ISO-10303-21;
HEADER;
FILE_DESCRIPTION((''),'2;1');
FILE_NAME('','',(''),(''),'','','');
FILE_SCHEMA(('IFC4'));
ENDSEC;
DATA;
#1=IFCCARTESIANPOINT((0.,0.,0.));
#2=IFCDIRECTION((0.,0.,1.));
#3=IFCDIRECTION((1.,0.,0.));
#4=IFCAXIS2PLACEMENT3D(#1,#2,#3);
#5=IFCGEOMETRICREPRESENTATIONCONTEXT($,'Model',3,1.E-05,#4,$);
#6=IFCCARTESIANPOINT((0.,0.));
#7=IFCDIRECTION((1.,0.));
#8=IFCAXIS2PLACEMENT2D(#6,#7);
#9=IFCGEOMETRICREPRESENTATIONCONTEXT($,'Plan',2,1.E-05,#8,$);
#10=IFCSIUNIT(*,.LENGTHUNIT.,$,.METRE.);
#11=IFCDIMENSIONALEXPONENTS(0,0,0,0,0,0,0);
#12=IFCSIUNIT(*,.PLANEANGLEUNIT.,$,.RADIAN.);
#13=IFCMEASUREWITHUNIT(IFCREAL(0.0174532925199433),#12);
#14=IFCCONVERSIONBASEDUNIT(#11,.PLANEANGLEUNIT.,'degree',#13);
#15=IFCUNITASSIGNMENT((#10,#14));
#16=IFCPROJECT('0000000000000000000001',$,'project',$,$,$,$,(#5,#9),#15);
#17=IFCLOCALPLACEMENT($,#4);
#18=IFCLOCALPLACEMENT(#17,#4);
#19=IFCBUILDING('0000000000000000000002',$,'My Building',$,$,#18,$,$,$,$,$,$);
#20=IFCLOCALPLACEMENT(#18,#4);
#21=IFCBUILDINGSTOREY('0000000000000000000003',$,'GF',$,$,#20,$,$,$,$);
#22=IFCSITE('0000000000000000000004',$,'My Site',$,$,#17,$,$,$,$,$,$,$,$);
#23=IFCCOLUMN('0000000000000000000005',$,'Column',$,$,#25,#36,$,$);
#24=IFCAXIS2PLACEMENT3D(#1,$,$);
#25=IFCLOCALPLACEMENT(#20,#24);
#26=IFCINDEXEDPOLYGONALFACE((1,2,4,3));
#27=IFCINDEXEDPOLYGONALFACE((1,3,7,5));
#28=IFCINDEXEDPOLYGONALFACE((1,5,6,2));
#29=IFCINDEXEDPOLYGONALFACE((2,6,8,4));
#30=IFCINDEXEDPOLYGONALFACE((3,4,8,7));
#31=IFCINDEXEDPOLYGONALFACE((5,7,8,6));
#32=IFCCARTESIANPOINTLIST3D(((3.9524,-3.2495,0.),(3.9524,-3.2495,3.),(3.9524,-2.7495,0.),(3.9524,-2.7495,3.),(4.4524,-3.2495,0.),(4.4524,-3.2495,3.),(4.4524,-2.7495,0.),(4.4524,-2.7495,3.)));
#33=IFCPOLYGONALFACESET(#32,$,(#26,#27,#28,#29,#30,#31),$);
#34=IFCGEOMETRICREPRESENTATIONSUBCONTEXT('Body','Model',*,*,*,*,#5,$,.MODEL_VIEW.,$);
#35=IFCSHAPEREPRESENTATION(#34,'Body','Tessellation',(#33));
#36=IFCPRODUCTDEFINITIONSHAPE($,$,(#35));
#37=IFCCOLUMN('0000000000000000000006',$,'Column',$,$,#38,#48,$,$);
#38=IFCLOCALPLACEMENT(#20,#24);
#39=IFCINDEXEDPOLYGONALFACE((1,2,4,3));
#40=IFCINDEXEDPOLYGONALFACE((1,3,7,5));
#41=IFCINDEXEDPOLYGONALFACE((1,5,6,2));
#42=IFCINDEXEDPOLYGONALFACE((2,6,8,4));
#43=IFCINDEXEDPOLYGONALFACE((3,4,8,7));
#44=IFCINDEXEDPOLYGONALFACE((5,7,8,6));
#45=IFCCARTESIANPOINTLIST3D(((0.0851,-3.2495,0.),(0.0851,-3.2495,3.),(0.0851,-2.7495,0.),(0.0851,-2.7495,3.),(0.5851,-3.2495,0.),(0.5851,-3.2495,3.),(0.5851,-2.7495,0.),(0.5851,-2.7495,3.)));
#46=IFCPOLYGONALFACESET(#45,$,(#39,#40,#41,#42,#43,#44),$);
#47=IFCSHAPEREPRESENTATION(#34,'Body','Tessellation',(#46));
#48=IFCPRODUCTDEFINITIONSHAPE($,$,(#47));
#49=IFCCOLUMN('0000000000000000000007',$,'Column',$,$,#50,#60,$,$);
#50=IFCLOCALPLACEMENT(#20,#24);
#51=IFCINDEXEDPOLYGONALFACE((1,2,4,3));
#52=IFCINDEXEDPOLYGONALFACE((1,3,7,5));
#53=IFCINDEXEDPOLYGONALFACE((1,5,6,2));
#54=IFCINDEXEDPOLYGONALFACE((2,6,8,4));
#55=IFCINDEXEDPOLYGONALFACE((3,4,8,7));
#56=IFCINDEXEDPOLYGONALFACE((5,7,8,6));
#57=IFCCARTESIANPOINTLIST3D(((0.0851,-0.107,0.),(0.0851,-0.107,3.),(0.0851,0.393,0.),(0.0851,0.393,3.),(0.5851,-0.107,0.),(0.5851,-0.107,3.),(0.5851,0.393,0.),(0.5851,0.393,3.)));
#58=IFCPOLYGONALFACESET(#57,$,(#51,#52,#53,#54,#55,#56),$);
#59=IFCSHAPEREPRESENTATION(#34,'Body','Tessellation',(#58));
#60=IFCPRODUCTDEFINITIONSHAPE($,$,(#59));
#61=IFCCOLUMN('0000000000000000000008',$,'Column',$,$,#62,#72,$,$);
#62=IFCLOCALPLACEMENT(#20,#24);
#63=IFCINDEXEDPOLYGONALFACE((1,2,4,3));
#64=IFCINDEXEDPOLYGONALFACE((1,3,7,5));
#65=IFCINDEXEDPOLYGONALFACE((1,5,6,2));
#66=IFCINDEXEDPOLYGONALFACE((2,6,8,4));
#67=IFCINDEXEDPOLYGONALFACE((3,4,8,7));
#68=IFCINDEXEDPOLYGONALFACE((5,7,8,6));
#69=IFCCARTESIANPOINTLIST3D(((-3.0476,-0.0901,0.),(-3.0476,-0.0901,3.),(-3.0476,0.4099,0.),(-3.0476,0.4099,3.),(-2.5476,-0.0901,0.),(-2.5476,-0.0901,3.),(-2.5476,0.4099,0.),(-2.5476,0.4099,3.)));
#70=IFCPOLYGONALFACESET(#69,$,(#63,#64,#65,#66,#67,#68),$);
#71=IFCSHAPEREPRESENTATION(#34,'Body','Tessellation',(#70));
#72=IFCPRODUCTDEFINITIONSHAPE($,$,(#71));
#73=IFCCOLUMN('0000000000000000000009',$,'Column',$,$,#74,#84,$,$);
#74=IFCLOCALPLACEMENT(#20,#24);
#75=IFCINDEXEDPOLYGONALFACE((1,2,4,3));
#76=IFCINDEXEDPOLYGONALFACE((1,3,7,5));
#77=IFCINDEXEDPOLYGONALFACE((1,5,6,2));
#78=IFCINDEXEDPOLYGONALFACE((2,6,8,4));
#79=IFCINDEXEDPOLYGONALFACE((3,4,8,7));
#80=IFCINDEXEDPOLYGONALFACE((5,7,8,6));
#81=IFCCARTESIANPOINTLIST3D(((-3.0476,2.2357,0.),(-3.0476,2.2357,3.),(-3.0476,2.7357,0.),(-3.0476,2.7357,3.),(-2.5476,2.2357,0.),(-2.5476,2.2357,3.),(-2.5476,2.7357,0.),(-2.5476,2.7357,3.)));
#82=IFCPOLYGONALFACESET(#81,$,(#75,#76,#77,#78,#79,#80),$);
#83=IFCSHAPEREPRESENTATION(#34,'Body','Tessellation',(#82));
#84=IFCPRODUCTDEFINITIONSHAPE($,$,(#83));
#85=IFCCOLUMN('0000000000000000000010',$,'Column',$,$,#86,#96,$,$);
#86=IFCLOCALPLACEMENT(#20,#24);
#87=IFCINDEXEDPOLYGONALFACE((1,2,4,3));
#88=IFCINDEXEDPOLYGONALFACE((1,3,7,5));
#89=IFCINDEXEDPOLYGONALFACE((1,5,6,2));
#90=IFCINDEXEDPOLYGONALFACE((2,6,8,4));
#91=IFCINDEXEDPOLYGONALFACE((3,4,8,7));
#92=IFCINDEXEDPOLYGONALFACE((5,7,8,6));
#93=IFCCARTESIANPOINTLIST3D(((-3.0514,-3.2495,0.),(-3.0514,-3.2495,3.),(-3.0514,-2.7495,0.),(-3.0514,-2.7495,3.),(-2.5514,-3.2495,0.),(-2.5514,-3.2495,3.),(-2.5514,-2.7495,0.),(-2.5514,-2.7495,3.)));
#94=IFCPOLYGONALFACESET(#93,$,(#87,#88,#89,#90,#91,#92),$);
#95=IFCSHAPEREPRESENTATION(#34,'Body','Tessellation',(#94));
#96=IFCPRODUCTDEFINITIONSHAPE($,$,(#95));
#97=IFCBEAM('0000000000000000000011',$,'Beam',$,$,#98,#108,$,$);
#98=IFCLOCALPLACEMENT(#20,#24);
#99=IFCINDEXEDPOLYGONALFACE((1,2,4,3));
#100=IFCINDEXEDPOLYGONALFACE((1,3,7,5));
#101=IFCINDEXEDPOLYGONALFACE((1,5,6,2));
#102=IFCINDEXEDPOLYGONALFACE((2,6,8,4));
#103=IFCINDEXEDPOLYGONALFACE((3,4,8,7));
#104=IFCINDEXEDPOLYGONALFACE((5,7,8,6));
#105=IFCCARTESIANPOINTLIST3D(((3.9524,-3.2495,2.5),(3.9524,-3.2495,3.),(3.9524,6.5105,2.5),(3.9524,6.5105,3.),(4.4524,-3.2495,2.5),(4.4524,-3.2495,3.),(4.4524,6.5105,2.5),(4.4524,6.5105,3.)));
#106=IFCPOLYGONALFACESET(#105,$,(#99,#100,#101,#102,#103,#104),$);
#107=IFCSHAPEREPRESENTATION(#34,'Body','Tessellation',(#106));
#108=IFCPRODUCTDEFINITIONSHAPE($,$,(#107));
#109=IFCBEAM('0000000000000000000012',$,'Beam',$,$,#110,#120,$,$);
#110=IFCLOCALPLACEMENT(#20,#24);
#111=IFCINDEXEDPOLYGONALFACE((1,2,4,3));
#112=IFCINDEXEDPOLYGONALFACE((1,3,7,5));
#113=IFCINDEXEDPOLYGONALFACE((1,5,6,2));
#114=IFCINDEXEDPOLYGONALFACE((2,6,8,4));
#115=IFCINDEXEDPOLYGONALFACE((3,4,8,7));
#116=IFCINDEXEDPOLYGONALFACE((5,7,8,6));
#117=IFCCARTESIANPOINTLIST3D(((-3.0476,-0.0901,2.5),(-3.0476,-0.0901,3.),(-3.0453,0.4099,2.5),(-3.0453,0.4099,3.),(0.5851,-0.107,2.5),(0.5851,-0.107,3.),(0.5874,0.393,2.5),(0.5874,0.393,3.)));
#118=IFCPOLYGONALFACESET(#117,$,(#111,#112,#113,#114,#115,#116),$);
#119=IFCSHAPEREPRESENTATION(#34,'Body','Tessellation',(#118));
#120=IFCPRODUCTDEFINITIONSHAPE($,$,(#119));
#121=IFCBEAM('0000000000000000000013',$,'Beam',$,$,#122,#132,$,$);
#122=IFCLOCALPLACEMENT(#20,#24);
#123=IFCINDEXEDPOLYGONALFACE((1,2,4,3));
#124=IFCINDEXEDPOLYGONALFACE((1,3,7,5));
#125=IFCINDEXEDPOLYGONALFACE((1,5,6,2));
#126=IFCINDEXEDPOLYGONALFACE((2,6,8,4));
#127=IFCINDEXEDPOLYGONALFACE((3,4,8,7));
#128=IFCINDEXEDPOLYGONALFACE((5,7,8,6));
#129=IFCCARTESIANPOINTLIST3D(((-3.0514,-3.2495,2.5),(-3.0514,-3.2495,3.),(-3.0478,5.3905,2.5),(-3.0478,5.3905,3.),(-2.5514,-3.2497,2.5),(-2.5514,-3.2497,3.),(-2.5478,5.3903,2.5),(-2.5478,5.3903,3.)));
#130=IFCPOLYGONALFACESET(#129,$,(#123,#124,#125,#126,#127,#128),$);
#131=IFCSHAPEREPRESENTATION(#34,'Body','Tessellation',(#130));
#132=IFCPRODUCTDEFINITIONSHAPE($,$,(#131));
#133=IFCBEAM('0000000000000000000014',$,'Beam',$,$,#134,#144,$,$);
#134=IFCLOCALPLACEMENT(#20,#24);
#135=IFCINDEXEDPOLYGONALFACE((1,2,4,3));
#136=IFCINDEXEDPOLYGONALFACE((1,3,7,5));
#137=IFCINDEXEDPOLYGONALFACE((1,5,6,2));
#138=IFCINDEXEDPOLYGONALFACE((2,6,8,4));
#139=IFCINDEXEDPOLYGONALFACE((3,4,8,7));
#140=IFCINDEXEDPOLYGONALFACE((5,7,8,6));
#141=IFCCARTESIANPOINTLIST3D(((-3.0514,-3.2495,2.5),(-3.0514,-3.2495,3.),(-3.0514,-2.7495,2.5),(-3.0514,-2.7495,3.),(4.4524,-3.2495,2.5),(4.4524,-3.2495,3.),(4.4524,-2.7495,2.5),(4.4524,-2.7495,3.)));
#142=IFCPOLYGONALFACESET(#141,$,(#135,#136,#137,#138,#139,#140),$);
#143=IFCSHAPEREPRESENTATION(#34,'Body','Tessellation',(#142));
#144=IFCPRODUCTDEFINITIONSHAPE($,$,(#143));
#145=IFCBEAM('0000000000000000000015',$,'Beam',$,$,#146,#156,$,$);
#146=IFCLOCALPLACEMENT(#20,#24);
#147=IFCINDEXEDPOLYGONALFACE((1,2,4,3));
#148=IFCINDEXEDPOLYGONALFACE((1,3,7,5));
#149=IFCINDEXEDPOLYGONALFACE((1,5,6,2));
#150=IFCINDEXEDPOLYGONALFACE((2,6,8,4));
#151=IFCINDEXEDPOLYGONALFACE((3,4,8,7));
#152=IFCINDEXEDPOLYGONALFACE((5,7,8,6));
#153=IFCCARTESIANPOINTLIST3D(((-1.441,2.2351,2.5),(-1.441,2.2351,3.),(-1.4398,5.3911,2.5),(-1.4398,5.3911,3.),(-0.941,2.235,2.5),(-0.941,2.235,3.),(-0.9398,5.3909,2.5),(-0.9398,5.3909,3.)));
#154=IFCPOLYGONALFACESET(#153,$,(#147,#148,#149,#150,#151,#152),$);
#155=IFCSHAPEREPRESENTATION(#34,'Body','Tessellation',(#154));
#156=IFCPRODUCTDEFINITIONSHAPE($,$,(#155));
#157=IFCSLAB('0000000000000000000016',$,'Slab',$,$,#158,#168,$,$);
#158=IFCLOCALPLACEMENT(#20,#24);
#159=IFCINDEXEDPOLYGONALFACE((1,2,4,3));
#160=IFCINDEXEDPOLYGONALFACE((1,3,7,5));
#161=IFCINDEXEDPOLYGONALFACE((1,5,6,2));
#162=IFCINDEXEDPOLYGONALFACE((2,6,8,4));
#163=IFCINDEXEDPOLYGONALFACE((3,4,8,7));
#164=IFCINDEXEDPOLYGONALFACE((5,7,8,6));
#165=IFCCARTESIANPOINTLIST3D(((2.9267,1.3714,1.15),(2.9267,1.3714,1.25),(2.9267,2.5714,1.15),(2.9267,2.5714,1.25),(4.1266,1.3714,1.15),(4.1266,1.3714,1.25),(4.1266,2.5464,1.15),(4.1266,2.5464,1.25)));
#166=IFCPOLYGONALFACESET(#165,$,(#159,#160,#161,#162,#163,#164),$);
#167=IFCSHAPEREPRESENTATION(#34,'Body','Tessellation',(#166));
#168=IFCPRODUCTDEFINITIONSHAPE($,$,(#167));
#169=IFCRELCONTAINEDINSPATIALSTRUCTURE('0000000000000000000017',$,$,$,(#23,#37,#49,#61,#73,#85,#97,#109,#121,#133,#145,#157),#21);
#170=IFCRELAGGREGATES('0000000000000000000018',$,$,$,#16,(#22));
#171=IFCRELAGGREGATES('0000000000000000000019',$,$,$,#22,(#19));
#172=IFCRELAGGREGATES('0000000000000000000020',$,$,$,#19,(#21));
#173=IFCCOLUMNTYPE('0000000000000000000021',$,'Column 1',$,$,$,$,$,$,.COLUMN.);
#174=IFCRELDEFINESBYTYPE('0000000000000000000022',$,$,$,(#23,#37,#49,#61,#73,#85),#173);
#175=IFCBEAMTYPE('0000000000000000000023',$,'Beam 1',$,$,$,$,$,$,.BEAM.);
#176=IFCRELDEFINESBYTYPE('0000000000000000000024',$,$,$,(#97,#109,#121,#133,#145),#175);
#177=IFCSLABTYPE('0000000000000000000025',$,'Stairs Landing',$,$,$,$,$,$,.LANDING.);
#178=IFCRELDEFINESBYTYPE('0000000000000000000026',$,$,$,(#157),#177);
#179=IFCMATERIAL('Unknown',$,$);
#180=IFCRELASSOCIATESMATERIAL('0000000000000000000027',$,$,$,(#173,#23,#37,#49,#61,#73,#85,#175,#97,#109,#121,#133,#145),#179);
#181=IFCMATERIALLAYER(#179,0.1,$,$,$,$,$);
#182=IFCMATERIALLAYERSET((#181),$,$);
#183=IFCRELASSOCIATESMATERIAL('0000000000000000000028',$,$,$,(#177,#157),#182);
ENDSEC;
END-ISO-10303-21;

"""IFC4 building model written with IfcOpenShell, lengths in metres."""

from ifc_helpers import new_model, entity, si_unit, converted_unit, frame, origin_with_axes, origin_2d_with_axis, place, context, subcontext, project, spatial, indexed_curve, outline, extrude, material, layer, layer_set, layer_usage, material_profile, profile_set, profile_usage, type_object, element, save


model = new_model("IFC4")

# Units and contexts
model_context = context("Model", 3, precision=1e-05, world=origin_with_axes())
plan_context = context("Plan", 2, precision=1e-05, world=origin_2d_with_axis())
body_context_1 = subcontext(model_context, "Body", "Model", "MODEL_VIEW")
ifc_project = project(units=[si_unit("LENGTHUNIT", "METRE"), converted_unit("PLANEANGLEUNIT", "degree", entity("IfcReal", 0.0174532925199433), si_unit("PLANEANGLEUNIT", "RADIAN"), dimensions=[0, 0, 0, 0, 0, 0, 0])], contexts=[model_context, plan_context])

# Site, building, storey
site_placement = place(None, origin_with_axes())
site = spatial("IfcSite", under=ifc_project, at=site_placement, Name="My Site")
building_placement = place(site_placement, origin_with_axes())
building = spatial("IfcBuilding", under=site, at=building_placement, Name="My Building")
storey_placement = place(building_placement, origin_with_axes())
storey = spatial("IfcBuildingStorey", under=building, at=storey_placement, Name="GF")

# Columns
ifc_material = material(Name="Unknown")
ifc_material_profile_1 = material_profile(ifc_material, outline(indexed_curve([(-0.25, -0.25), (0.25, -0.25), (0.25, 0.25), (-0.25, 0.25), (-0.25, -0.25)])))
ifc_profile_set_1 = profile_set([ifc_material_profile_1])
ifc_profile_usage_1 = profile_usage(ifc_profile_set_1, cardinal=1)
column_type = type_object("IfcColumnType", Name="Column 1", PredefinedType="COLUMN", material=ifc_profile_set_1)
column_1_placement = place(storey_placement, frame((4.4524, -3.2495, 0.0), z_axis=(0.0, 0.0, 1.0), x_axis=(1.0, 0.0, 0.0)))
element("IfcColumn", 1, at=column_1_placement, inside=storey, type_object=column_type, material=ifc_profile_usage_1, Name="Column", context=body_context_1, shape_type="SweptSolid", body=[
    extrude(outline(indexed_curve([(-0.25, -0.25), (0.25, -0.25), (0.25, 0.25), (-0.25, 0.25), (-0.25, -0.25)])), frame((-0.25, 0.25, 0.0), z_axis=(0.0, 0.0, 1.0), x_axis=(1.0, 0.0, 0.0)), (0.0, 0.0, 1.0), 3.0),
])
ifc_profile_usage_2 = profile_usage(ifc_profile_set_1, cardinal=1)
column_2_placement = place(storey_placement, frame((0.5851, -3.2495, 0.0), z_axis=(0.0, 0.0, 1.0), x_axis=(1.0, 0.0, 0.0)))
element("IfcColumn", 2, at=column_2_placement, inside=storey, type_object=column_type, material=ifc_profile_usage_2, Name="Column", context=body_context_1, shape_type="SweptSolid", body=[
    extrude(outline(indexed_curve([(-0.25, -0.25), (0.25, -0.25), (0.25, 0.25), (-0.25, 0.25), (-0.25, -0.25)])), frame((-0.25, 0.25, 0.0), z_axis=(0.0, 0.0, 1.0), x_axis=(1.0, 0.0, 0.0)), (0.0, 0.0, 1.0), 3.0),
])
ifc_profile_usage_3 = profile_usage(ifc_profile_set_1, cardinal=3)
column_3_placement = place(storey_placement, frame((0.0851, -0.107, 0.0), z_axis=(0.0, 0.0, 1.0), x_axis=(1.0, 0.0, 0.0)))
element("IfcColumn", 3, at=column_3_placement, inside=storey, type_object=column_type, material=ifc_profile_usage_3, Name="Column", context=body_context_1, shape_type="SweptSolid", body=[
    extrude(outline(indexed_curve([(-0.25, -0.25), (0.25, -0.25), (0.25, 0.25), (-0.25, 0.25), (-0.25, -0.25)])), frame((0.25, 0.25, 0.0), z_axis=(0.0, 0.0, 1.0), x_axis=(1.0, 0.0, 0.0)), (0.0, 0.0, 1.0), 3.0),
])
ifc_profile_usage_4 = profile_usage(ifc_profile_set_1, cardinal=3)
column_4_placement = place(storey_placement, frame((-3.0476, -0.0901, 0.0), z_axis=(0.0, 0.0, 1.0), x_axis=(1.0, 0.0, 0.0)))
element("IfcColumn", 4, at=column_4_placement, inside=storey, type_object=column_type, material=ifc_profile_usage_4, Name="Column", context=body_context_1, shape_type="SweptSolid", body=[
    extrude(outline(indexed_curve([(-0.25, -0.25), (0.25, -0.25), (0.25, 0.25), (-0.25, 0.25), (-0.25, -0.25)])), frame((0.25, 0.25, 0.0), z_axis=(0.0, 0.0, 1.0), x_axis=(1.0, 0.0, 0.0)), (0.0, 0.0, 1.0), 3.0),
])
ifc_profile_usage_5 = profile_usage(ifc_profile_set_1, cardinal=3)
column_5_placement = place(storey_placement, frame((-3.0476, 2.2357, 0.0), z_axis=(0.0, 0.0, 1.0), x_axis=(1.0, 0.0, 0.0)))
element("IfcColumn", 5, at=column_5_placement, inside=storey, type_object=column_type, material=ifc_profile_usage_5, Name="Column", context=body_context_1, shape_type="SweptSolid", body=[
    extrude(outline(indexed_curve([(-0.25, -0.25), (0.25, -0.25), (0.25, 0.25), (-0.25, 0.25), (-0.25, -0.25)])), frame((0.25, 0.25, 0.0), z_axis=(0.0, 0.0, 1.0), x_axis=(1.0, 0.0, 0.0)), (0.0, 0.0, 1.0), 3.0),
])
ifc_profile_usage_6 = profile_usage(ifc_profile_set_1, cardinal=1)
column_6_placement = place(storey_placement, frame((-2.5514, -3.2495, 0.0), z_axis=(0.0, 0.0, 1.0), x_axis=(1.0, 0.0, 0.0)))
element("IfcColumn", 6, at=column_6_placement, inside=storey, type_object=column_type, material=ifc_profile_usage_6, Name="Column", context=body_context_1, shape_type="SweptSolid", body=[
    extrude(outline(indexed_curve([(-0.25, -0.25), (0.25, -0.25), (0.25, 0.25), (-0.25, 0.25), (-0.25, -0.25)])), frame((-0.25, 0.25, 0.0), z_axis=(0.0, 0.0, 1.0), x_axis=(1.0, 0.0, 0.0)), (0.0, 0.0, 1.0), 3.0),
])

# Beams
ifc_material_profile_2 = material_profile(ifc_material, outline(indexed_curve([(-0.25, -0.25), (0.25, -0.25), (0.25, 0.25), (-0.25, 0.25), (-0.25, -0.25)])))
ifc_profile_set_2 = profile_set([ifc_material_profile_2])
ifc_profile_usage_7 = profile_usage(ifc_profile_set_2, cardinal=9)
beam_type = type_object("IfcBeamType", Name="Beam 1", PredefinedType="BEAM", material=ifc_profile_set_2)
beam_1_placement = place(storey_placement, frame((4.4524, -3.2495, 3.0), z_axis=(0.0, 1.0, 0.0), x_axis=(-1.0, 0.0, 0.0)))
element("IfcBeam", 7, at=beam_1_placement, inside=storey, type_object=beam_type, material=ifc_profile_usage_7, Name="Beam", context=body_context_1, shape_type="SweptSolid", body=[
    extrude(outline(indexed_curve([(-0.25, -0.25), (0.25, -0.25), (0.25, 0.25), (-0.25, 0.25), (-0.25, -0.25)])), frame((0.25, -0.25, 0.0), z_axis=(0.0, 0.0, 1.0), x_axis=(1.0, 0.0, 0.0)), (0.0, 0.0, 1.0), 9.76),
])
ifc_profile_usage_8 = profile_usage(ifc_profile_set_2, cardinal=9)
beam_2_placement = place(storey_placement, frame((-3.0476, -0.0901, 3.0), z_axis=(0.999989, -0.004657, 0.0), x_axis=(0.004657, 0.999989, 0.0)))
element("IfcBeam", 8, at=beam_2_placement, inside=storey, type_object=beam_type, material=ifc_profile_usage_8, Name="Beam", context=body_context_1, shape_type="SweptSolid", body=[
    extrude(outline(indexed_curve([(-0.25, -0.25), (0.25, -0.25), (0.25, 0.25), (-0.25, 0.25), (-0.25, -0.25)])), frame((0.25, -0.25, 0.0), z_axis=(0.0, 0.0, 1.0), x_axis=(1.0, 0.0, 0.0)), (0.0, 0.0, 1.0), 3.6328),
])
ifc_profile_usage_9 = profile_usage(ifc_profile_set_2, cardinal=7)
beam_3_placement = place(storey_placement, frame((-3.0514, -3.2495, 3.0), z_axis=(0.000422, 1.0, 0.0), x_axis=(-1.0, 0.000422, 0.0)))
element("IfcBeam", 9, at=beam_3_placement, inside=storey, type_object=beam_type, material=ifc_profile_usage_9, Name="Beam", context=body_context_1, shape_type="SweptSolid", body=[
    extrude(outline(indexed_curve([(-0.25, -0.25), (0.25, -0.25), (0.25, 0.25), (-0.25, 0.25), (-0.25, -0.25)])), frame((-0.25, -0.25, 0.0), z_axis=(0.0, 0.0, 1.0), x_axis=(1.0, 0.0, 0.0)), (0.0, 0.0, 1.0), 8.64),
])
ifc_profile_usage_10 = profile_usage(ifc_profile_set_2, cardinal=7)
beam_4_placement = place(storey_placement, frame((4.4524, -3.2495, 3.0), z_axis=(-1.0, 0.0, 0.0), x_axis=(0.0, -1.0, 0.0)))
element("IfcBeam", 10, at=beam_4_placement, inside=storey, type_object=beam_type, material=ifc_profile_usage_10, Name="Beam", context=body_context_1, shape_type="SweptSolid", body=[
    extrude(outline(indexed_curve([(-0.25, -0.25), (0.25, -0.25), (0.25, 0.25), (-0.25, 0.25), (-0.25, -0.25)])), frame((-0.25, -0.25, 0.0), z_axis=(0.0, 0.0, 1.0), x_axis=(1.0, 0.0, 0.0)), (0.0, 0.0, 1.0), 7.5038),
])
ifc_profile_usage_11 = profile_usage(ifc_profile_set_2, cardinal=5)
beam_5_placement = place(storey_placement, frame((-1.191, 2.235, 2.75), z_axis=(0.000385, 1.0, 0.0), x_axis=(-1.0, 0.000385, 0.0)))
element("IfcBeam", 11, at=beam_5_placement, inside=storey, type_object=beam_type, material=ifc_profile_usage_11, Name="Beam", context=body_context_1, shape_type="SweptSolid", body=[
    extrude(outline(indexed_curve([(-0.25, -0.25), (0.25, -0.25), (0.25, 0.25), (-0.25, 0.25), (-0.25, -0.25)])), origin_with_axes(), (0.0, 0.0, 1.0), 3.156),
])

# Slab
ifc_layer_1 = layer(ifc_material, 0.1)
ifc_layer_set_1 = layer_set([ifc_layer_1])
ifc_layer_usage_1 = layer_usage(ifc_layer_set_1, "AXIS3", "POSITIVE", -0.1)
slab_type_1 = type_object("IfcSlabType", Name="Stairs Landing", PredefinedType="LANDING", material=ifc_layer_set_1)
slab_1_placement = place(storey_placement, frame((4.1267, 1.3714, 1.25), z_axis=(0.0, 0.0, 1.0), x_axis=(1.0, 0.0, 0.0)))
element("IfcSlab", 12, at=slab_1_placement, inside=storey, type_object=slab_type_1, material=ifc_layer_usage_1, Name="Slab", context=body_context_1, shape_type="SweptSolid", body=[
    extrude(outline(indexed_curve([(-0.0001, -0.0001), (-0.0001, 1.175), (-1.2, 1.2), (-1.2, 0.0), (-0.0001, -0.0001)])), frame((0.0, 0.0, -0.1), z_axis=(0.0, 0.0, 1.0), x_axis=(1.0, 0.0, 0.0)), (0.0, 0.0, 1.0), 0.1),
])

save(model, "model.ifc")
